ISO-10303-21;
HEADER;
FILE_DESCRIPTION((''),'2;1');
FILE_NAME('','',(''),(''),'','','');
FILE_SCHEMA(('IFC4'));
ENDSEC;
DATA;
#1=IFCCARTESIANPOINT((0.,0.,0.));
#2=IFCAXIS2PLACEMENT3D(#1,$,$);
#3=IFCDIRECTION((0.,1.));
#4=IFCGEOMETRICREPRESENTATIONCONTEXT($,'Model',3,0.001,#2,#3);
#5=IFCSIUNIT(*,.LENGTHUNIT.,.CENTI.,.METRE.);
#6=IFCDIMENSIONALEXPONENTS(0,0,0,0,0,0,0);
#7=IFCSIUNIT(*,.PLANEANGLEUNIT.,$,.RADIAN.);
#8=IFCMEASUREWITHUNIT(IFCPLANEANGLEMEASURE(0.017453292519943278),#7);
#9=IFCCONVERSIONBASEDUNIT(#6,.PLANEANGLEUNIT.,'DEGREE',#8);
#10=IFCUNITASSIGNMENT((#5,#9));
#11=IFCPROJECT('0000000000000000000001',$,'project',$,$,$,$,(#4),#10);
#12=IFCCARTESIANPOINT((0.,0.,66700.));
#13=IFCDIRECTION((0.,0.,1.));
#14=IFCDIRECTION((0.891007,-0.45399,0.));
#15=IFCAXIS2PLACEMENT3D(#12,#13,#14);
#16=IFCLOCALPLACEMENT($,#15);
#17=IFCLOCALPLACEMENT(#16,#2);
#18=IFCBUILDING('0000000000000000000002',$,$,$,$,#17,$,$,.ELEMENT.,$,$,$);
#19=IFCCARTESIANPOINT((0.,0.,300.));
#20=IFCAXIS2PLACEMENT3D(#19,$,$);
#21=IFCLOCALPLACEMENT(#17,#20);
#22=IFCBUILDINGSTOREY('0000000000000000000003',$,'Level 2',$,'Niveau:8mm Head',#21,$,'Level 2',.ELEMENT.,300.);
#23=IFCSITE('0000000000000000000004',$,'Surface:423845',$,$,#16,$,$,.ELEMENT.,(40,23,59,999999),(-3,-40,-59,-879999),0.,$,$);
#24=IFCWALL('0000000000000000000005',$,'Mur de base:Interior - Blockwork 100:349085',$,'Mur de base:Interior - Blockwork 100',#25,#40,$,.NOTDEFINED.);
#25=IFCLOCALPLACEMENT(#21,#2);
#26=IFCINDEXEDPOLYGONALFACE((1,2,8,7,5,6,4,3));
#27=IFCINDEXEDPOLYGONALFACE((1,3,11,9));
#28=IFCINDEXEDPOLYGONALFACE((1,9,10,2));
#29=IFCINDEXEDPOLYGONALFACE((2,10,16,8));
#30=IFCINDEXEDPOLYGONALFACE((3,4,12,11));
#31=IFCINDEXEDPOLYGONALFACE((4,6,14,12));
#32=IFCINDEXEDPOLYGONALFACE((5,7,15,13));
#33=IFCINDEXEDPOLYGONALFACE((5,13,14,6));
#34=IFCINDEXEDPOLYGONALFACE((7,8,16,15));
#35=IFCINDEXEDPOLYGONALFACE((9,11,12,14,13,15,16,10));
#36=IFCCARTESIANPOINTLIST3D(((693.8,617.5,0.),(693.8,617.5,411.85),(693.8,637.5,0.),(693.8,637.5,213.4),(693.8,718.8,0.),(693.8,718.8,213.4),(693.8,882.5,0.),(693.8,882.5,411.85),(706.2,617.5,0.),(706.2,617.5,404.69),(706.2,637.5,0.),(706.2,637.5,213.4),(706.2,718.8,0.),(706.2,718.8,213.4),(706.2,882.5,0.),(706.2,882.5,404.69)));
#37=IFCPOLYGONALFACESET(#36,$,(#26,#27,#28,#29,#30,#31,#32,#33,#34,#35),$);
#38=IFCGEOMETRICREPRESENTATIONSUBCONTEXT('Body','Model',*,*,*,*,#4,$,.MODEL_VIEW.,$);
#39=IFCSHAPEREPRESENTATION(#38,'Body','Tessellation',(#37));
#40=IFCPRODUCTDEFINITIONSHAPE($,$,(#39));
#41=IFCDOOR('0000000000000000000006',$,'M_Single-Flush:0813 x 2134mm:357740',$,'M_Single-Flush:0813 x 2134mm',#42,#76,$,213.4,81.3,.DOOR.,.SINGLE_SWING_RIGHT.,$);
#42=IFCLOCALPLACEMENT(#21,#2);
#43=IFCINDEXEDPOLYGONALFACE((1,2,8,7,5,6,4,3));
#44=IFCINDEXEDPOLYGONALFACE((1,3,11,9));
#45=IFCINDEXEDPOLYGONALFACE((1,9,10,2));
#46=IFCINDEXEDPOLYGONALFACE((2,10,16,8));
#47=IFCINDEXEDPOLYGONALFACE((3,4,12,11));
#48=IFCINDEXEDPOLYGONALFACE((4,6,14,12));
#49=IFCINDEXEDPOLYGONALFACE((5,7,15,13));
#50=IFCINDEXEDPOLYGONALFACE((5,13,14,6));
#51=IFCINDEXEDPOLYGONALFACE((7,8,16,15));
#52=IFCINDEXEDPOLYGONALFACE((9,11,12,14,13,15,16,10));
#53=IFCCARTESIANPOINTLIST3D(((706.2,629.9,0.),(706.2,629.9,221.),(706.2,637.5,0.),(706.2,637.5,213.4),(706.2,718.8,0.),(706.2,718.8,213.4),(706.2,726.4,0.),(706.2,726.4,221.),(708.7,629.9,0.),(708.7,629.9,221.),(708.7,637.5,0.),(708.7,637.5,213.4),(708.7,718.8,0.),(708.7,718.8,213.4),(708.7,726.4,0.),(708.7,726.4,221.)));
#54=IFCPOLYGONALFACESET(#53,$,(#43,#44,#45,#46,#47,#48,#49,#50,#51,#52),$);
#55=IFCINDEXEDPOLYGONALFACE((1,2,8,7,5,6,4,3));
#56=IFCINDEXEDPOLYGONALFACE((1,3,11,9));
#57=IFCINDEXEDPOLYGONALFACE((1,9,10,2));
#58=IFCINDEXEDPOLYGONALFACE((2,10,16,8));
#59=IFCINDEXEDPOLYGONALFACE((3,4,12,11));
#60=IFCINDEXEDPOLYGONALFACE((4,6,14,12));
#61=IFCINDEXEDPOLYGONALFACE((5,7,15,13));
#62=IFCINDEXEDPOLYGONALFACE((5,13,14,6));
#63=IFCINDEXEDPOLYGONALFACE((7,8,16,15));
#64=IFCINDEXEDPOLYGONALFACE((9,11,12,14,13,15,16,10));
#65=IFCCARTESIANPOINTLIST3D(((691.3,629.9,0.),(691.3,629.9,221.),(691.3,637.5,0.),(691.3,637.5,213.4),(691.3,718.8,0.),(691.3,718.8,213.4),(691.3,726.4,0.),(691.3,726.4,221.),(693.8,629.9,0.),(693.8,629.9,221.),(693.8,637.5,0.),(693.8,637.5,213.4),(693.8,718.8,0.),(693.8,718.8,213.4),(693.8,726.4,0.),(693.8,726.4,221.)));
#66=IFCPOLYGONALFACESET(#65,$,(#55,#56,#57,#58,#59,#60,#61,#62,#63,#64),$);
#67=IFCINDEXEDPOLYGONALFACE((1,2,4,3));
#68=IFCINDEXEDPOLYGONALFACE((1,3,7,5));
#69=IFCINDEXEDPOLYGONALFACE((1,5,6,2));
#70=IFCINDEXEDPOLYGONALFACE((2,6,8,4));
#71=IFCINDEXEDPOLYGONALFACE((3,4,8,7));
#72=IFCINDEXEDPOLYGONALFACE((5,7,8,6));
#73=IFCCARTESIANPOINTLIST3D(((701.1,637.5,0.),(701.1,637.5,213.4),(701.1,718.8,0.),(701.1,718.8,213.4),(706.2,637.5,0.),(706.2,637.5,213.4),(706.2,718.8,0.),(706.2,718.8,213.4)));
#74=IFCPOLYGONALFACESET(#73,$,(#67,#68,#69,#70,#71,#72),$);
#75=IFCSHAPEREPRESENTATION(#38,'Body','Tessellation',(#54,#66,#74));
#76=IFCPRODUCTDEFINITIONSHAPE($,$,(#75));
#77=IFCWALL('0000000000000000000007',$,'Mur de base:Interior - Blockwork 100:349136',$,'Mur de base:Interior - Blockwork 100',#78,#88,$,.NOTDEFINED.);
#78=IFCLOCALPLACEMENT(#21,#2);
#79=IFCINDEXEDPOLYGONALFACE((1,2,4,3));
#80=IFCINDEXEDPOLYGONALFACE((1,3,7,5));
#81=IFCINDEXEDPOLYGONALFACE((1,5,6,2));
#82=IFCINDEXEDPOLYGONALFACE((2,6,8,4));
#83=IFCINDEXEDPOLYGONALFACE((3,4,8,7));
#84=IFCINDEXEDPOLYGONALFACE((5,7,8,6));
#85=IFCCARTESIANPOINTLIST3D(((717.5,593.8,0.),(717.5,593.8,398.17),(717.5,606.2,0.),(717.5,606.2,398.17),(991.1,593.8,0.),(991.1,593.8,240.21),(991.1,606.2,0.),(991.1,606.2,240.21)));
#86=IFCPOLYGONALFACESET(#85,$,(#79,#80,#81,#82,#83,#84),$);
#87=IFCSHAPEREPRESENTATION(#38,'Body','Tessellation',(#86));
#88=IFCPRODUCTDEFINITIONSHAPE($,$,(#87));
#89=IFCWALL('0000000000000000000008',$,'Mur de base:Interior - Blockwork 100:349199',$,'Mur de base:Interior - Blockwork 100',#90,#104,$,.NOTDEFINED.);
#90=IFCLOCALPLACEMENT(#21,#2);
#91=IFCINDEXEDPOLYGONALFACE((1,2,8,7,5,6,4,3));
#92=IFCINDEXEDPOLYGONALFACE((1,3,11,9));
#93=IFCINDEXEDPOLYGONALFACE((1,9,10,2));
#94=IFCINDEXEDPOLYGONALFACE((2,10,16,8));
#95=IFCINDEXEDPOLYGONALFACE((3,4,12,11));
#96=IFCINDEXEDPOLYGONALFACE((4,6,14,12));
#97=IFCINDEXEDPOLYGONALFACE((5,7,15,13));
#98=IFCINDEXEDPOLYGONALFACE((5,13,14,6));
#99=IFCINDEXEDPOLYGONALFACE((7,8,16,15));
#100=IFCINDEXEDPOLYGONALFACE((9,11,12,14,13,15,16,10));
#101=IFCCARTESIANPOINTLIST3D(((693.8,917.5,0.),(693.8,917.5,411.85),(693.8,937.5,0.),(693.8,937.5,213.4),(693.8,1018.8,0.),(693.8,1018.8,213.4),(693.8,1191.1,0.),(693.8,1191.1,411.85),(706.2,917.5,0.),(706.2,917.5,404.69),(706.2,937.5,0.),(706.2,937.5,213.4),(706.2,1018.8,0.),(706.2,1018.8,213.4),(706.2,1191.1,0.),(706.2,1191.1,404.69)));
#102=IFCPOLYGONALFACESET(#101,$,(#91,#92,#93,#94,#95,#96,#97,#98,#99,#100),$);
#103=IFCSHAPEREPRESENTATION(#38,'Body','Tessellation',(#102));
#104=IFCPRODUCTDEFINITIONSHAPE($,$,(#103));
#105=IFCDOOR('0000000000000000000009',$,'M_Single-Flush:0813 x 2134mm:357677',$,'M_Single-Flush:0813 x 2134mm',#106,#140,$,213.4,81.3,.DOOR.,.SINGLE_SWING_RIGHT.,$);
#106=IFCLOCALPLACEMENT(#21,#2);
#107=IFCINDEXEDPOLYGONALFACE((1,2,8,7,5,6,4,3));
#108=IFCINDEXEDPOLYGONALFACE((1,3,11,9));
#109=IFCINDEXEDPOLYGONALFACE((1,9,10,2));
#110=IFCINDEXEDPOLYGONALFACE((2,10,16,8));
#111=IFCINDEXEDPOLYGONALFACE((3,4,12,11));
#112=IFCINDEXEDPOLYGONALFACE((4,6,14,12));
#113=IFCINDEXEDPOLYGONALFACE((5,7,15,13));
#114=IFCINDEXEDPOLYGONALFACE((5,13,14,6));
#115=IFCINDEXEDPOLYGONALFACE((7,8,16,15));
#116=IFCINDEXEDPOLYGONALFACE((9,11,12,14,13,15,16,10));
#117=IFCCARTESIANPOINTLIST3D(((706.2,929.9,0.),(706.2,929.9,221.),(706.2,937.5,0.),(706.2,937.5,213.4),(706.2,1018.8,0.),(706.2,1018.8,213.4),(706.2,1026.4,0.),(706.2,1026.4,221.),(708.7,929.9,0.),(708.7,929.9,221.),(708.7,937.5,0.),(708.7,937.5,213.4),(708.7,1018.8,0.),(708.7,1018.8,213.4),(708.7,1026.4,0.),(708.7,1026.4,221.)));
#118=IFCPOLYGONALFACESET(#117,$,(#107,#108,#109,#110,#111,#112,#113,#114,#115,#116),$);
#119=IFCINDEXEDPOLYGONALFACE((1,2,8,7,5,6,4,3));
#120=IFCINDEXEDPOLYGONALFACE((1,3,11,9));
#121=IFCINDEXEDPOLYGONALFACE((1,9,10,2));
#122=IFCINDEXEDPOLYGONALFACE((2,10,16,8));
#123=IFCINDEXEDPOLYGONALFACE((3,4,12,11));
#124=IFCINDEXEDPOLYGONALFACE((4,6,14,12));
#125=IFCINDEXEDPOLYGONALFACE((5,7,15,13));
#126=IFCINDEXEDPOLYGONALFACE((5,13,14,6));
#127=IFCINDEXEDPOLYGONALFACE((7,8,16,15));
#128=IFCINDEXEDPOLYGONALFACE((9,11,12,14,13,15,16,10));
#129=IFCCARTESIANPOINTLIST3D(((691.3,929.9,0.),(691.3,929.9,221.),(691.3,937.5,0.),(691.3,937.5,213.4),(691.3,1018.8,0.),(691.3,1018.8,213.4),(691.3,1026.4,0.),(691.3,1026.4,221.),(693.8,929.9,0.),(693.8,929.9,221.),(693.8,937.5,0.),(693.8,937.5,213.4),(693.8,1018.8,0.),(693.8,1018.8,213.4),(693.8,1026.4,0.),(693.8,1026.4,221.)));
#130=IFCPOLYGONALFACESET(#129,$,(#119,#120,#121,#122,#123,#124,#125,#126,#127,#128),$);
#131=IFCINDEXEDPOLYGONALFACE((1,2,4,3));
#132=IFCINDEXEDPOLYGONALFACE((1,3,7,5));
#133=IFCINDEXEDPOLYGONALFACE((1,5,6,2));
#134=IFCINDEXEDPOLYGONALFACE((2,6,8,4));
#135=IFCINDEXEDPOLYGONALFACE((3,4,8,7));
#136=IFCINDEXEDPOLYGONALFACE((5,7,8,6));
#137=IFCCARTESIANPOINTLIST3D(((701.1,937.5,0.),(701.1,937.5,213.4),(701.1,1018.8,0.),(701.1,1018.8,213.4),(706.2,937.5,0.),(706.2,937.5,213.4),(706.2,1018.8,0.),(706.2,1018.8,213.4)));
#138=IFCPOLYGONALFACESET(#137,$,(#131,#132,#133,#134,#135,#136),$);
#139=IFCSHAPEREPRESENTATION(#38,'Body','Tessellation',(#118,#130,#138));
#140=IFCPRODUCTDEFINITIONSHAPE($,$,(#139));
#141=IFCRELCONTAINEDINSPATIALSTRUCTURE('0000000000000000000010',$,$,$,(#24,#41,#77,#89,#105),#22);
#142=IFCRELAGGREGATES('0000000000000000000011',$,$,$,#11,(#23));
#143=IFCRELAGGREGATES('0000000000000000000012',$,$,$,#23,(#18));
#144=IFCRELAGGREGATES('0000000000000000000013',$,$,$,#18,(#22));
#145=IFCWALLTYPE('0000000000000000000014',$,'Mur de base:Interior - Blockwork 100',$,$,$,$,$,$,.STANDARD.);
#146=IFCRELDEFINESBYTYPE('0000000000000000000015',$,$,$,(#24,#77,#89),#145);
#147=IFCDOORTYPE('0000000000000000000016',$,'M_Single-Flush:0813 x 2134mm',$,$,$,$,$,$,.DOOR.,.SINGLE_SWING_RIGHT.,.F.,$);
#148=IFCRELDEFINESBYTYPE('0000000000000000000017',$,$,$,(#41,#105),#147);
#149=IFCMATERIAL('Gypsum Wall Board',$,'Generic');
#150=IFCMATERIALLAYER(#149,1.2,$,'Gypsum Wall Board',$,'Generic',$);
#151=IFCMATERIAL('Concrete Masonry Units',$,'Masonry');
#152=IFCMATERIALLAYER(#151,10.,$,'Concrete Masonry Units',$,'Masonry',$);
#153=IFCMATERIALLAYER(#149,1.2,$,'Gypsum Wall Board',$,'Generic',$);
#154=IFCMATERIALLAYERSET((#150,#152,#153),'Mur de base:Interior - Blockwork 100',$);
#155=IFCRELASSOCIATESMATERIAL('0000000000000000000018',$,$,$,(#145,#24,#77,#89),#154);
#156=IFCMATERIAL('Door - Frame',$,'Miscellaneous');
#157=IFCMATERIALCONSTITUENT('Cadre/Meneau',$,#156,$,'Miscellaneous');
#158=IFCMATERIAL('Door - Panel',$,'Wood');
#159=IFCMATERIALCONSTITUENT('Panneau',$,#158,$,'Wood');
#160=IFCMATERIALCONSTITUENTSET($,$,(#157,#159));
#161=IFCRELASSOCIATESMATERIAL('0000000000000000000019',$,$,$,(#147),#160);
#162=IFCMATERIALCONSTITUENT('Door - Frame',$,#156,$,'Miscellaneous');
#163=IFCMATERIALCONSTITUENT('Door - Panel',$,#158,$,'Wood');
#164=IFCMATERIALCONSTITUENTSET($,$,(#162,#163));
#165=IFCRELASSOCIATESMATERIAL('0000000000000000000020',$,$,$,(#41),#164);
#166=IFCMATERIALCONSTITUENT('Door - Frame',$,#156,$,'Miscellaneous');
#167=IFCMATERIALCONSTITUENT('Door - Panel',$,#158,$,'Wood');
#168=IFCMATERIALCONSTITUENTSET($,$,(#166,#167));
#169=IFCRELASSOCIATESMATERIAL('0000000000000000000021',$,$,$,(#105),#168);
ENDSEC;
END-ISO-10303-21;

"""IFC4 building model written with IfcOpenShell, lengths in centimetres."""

from ifc_helpers import new_model, entity, si_unit, converted_unit, direction, frame, frame_2d, origin, origin_2d_with_axis, place, context, subcontext, project, spatial, polyline, rectangle, outline, extrude, clip, bounded_halfspace, source, transform, mapped, material, layer, layer_set, layer_usage, constituent, constituent_set, type_object, type_shapes, element, fill, save


model = new_model("IFC4")

# Units and contexts
model_context = context("Model", 3, precision=0.001, world=origin(), true_north=direction((0.0, 1.0)))
body_context = subcontext(model_context, "Body", "Model", "MODEL_VIEW")
ifc_project = project(units=[si_unit("LENGTHUNIT", "METRE", prefix="CENTI"), converted_unit("PLANEANGLEUNIT", "DEGREE", entity("IfcPlaneAngleMeasure", 0.017453292519943278), si_unit("PLANEANGLEUNIT", "RADIAN"), dimensions=[0, 0, 0, 0, 0, 0, 0])], contexts=[model_context])

# Site, building, storey
site_placement = place(None, frame((0.0, 0.0, 66700.0), z_axis=(0.0, 0.0, 1.0), x_axis=(0.891007, -0.45399, 0.0)))
site = spatial("IfcSite", under=ifc_project, at=site_placement, Name="Surface:423845", CompositionType="ELEMENT", RefLatitude=(40, 23, 59, 999999), RefLongitude=(-3, -40, -59, -879999), RefElevation=0.0)
building_placement = place(site_placement, origin())
building = spatial("IfcBuilding", under=site, at=building_placement, CompositionType="ELEMENT")
storey_placement = place(building_placement, frame((0.0, 0.0, 300.0)))
storey = spatial("IfcBuildingStorey", under=building, at=storey_placement, Name="Level 2", ObjectType="Niveau:8mm Head", LongName="Level 2", CompositionType="ELEMENT", Elevation=300.0)

# Shared definitions
ifc_material_1 = material(Name="Gypsum Wall Board", Category="Generic")
ifc_layer_1 = layer(ifc_material_1, 1.2, Name="Gypsum Wall Board", Category="Generic")
ifc_material_2 = material(Name="Concrete Masonry Units", Category="Masonry")
ifc_layer_2 = layer(ifc_material_2, 10.0, Name="Concrete Masonry Units", Category="Masonry")
ifc_layer_3 = layer(ifc_material_1, 1.2, Name="Gypsum Wall Board", Category="Generic")
ifc_layer_set_1 = layer_set([ifc_layer_1, ifc_layer_2, ifc_layer_3], Name="Mur de base:Interior - Blockwork 100")
wall_type = type_object("IfcWallType", Name="Mur de base:Interior - Blockwork 100", PredefinedType="STANDARD", material=ifc_layer_set_1)

# Wall, opening, door
ifc_layer_usage_1 = layer_usage(ifc_layer_set_1, "AXIS2", "NEGATIVE", 6.2)
wall_1_placement = place(storey_placement, frame((700.0, 882.5, 0.0), z_axis=(0.0, 0.0, 1.0), x_axis=(0.0, -1.0, 0.0)))
wall_1 = element("IfcWall", 1, at=wall_1_placement, inside=storey, type_object=wall_type, material=ifc_layer_usage_1, Name="Mur de base:Interior - Blockwork 100:349085", ObjectType="Mur de base:Interior - Blockwork 100", PredefinedType="NOTDEFINED", context=body_context, shape_type="Clipping", body=[
    clip(extrude(rectangle(XDim=265.0, YDim=12.4, at=frame_2d((132.5, 0.0), x_axis=(1.0, 0.0))), origin(), (0.0, 0.0, 1.0), 411.85), bounded_halfspace(frame((0.0, -6.2, 411.85), z_axis=(0.0, 0.5, 0.866025), x_axis=(-1.0, 0.0, 0.0)), False, frame((0.0, -6.2, 411.85)), polyline([(0.0, 0.0), (265.0, 0.0), (265.0, 12.4), (0.0, 12.4), (0.0, 0.0)]))),
])
opening_1_placement = place(wall_1_placement, frame((163.7, -6.2, 0.0)))
opening_1 = element("IfcOpeningElement", 2, at=opening_1_placement, cuts=wall_1, PredefinedType="OPENING", context=body_context, shape_type="SweptSolid", body=[
    extrude(rectangle(XDim=81.3, YDim=213.4, at=frame_2d((106.7, 40.65), x_axis=(0.0, 1.0))), frame((0.0, 0.0, 0.0), z_axis=(0.0, 1.0, 0.0), x_axis=(0.0, 0.0, 1.0)), (0.0, 0.0, 1.0), 12.4),
])
ifc_material_3 = material(Name="Door - Frame", Category="Miscellaneous")
ifc_constituent_1 = constituent(ifc_material_3, Name="Door - Frame", Category="Miscellaneous")
ifc_material_4 = material(Name="Door - Panel", Category="Wood")
ifc_constituent_2 = constituent(ifc_material_4, Name="Door - Panel", Category="Wood")
ifc_constituent_set_1 = constituent_set(constituents=[ifc_constituent_1, ifc_constituent_2])
ifc_constituent_3 = constituent(ifc_material_3, Name="Cadre/Meneau", Category="Miscellaneous")
ifc_constituent_4 = constituent(ifc_material_4, Name="Panneau", Category="Wood")
ifc_constituent_set_2 = constituent_set(constituents=[ifc_constituent_3, ifc_constituent_4])
door_type_1 = type_object("IfcDoorType", Name="M_Single-Flush:0813 x 2134mm", OperationType="SINGLE_SWING_RIGHT", ParameterTakesPrecedence=False, PredefinedType="DOOR", material=ifc_constituent_set_2)
shared_shape_1 = source(origin(), body_context, "Body", "SweptSolid", [
    extrude(outline(polyline([(-48.25, -112.4), (48.25, -112.4), (48.25, 108.6), (40.65, 108.6), (40.65, -104.8), (-40.65, -104.8), (-40.65, 108.6), (-48.25, 108.6), (-48.25, -112.4)])), frame((40.65, 12.4, 108.6), z_axis=(0.0, 1.0, 0.0), x_axis=(1.0, 0.0, 0.0)), (0.0, 0.0, 1.0), 2.5),
    extrude(outline(polyline([(-112.4, -48.25), (108.6, -48.25), (108.6, -40.65), (-104.8, -40.65), (-104.8, 40.65), (108.6, 40.65), (108.6, 48.25), (-112.4, 48.25), (-112.4, -48.25)])), frame((40.65, -2.5, 108.6), z_axis=(0.0, 1.0, 0.0), x_axis=(0.0, 0.0, -1.0)), (0.0, 0.0, 1.0), 2.5),
    extrude(rectangle(XDim=5.1, YDim=81.3, at=origin_2d_with_axis()), frame((40.65, 9.85, 0.0), z_axis=(0.0, 0.0, 1.0), x_axis=(0.0, 1.0, 0.0)), (0.0, 0.0, 1.0), 213.4),
])
type_shapes(door_type_1, [shared_shape_1])
door_1_placement = place(opening_1_placement, origin())
door_1 = element("IfcDoor", 3, at=door_1_placement, inside=storey, type_object=door_type_1, material=ifc_constituent_set_1, Name="M_Single-Flush:0813 x 2134mm:357740", ObjectType="M_Single-Flush:0813 x 2134mm", OperationType="SINGLE_SWING_RIGHT", OverallHeight=213.4, OverallWidth=81.3, PredefinedType="DOOR", context=body_context, shape_type="MappedRepresentation", body=[
    mapped(shared_shape_1, transform((0.0, 0.0, 0.0), scale=1.0)),
])
fill(opening_1, door_1)

# Wall
ifc_layer_usage_2 = layer_usage(ifc_layer_set_1, "AXIS2", "NEGATIVE", 6.2)
wall_2_placement = place(storey_placement, frame((717.5, 600.0, 0.0)))
element("IfcWall", 4, at=wall_2_placement, inside=storey, type_object=wall_type, material=ifc_layer_usage_2, Name="Mur de base:Interior - Blockwork 100:349136", ObjectType="Mur de base:Interior - Blockwork 100", PredefinedType="NOTDEFINED", context=body_context, shape_type="Clipping", body=[
    clip(extrude(rectangle(XDim=273.6, YDim=12.4, at=frame_2d((136.8, 0.0), x_axis=(-1.0, 0.0))), origin(), (0.0, 0.0, 1.0), 398.17), bounded_halfspace(frame((0.0, -6.2, 398.17), z_axis=(0.5, 0.0, 0.866025), x_axis=(0.0, 1.0, 0.0)), False, frame((0.0, -6.2, 398.17)), polyline([(0.0, 0.0), (273.6, 0.0), (273.6, 12.4), (0.0, 12.4), (0.0, 0.0)]))),
])

# Wall, opening, door
ifc_layer_usage_3 = layer_usage(ifc_layer_set_1, "AXIS2", "NEGATIVE", 6.2)
wall_3_placement = place(storey_placement, frame((700.0, 917.5, 0.0), z_axis=(0.0, 0.0, 1.0), x_axis=(0.0, 1.0, 0.0)))
wall_3 = element("IfcWall", 5, at=wall_3_placement, inside=storey, type_object=wall_type, material=ifc_layer_usage_3, Name="Mur de base:Interior - Blockwork 100:349199", ObjectType="Mur de base:Interior - Blockwork 100", PredefinedType="NOTDEFINED", context=body_context, shape_type="Clipping", body=[
    clip(extrude(rectangle(XDim=273.6, YDim=12.4, at=frame_2d((136.8, 0.0), x_axis=(1.0, 0.0))), origin(), (0.0, 0.0, 1.0), 411.85), bounded_halfspace(frame((0.0, -6.2, 404.69), z_axis=(0.0, -0.5, 0.866025), x_axis=(1.0, 0.0, 0.0)), False, frame((0.0, -6.2, 404.69)), polyline([(0.0, 0.0), (273.6, 0.0), (273.6, 12.4), (0.0, 12.4), (0.0, 0.0)]))),
])
opening_2_placement = place(wall_3_placement, frame((101.3, 6.2, 0.0)))
opening_2 = element("IfcOpeningElement", 6, at=opening_2_placement, cuts=wall_3, PredefinedType="OPENING", context=body_context, shape_type="SweptSolid", body=[
    extrude(rectangle(XDim=81.3, YDim=213.4, at=frame_2d((106.7, 40.65), x_axis=(0.0, 1.0))), frame((0.0, 0.0, 0.0), z_axis=(0.0, -1.0, 0.0), x_axis=(0.0, 0.0, 1.0)), (0.0, 0.0, 1.0), 12.4),
])
ifc_constituent_5 = constituent(ifc_material_3, Name="Door - Frame", Category="Miscellaneous")
ifc_constituent_6 = constituent(ifc_material_4, Name="Door - Panel", Category="Wood")
ifc_constituent_set_3 = constituent_set(constituents=[ifc_constituent_5, ifc_constituent_6])
door_2_placement = place(opening_2_placement, frame((0.0, 0.0, 0.0), z_axis=(0.0, 0.0, 1.0), x_axis=(-1.0, 0.0, 0.0)))
door_2 = element("IfcDoor", 7, at=door_2_placement, inside=storey, type_object=door_type_1, material=ifc_constituent_set_3, Name="M_Single-Flush:0813 x 2134mm:357677", ObjectType="M_Single-Flush:0813 x 2134mm", OperationType="SINGLE_SWING_RIGHT", OverallHeight=213.4, OverallWidth=81.3, PredefinedType="DOOR", context=body_context, shape_type="MappedRepresentation", body=[
    mapped(shared_shape_1, transform((0.0, 0.0, 0.0), scale=1.0)),
])
fill(opening_2, door_2)

save(model, "model.ifc")
